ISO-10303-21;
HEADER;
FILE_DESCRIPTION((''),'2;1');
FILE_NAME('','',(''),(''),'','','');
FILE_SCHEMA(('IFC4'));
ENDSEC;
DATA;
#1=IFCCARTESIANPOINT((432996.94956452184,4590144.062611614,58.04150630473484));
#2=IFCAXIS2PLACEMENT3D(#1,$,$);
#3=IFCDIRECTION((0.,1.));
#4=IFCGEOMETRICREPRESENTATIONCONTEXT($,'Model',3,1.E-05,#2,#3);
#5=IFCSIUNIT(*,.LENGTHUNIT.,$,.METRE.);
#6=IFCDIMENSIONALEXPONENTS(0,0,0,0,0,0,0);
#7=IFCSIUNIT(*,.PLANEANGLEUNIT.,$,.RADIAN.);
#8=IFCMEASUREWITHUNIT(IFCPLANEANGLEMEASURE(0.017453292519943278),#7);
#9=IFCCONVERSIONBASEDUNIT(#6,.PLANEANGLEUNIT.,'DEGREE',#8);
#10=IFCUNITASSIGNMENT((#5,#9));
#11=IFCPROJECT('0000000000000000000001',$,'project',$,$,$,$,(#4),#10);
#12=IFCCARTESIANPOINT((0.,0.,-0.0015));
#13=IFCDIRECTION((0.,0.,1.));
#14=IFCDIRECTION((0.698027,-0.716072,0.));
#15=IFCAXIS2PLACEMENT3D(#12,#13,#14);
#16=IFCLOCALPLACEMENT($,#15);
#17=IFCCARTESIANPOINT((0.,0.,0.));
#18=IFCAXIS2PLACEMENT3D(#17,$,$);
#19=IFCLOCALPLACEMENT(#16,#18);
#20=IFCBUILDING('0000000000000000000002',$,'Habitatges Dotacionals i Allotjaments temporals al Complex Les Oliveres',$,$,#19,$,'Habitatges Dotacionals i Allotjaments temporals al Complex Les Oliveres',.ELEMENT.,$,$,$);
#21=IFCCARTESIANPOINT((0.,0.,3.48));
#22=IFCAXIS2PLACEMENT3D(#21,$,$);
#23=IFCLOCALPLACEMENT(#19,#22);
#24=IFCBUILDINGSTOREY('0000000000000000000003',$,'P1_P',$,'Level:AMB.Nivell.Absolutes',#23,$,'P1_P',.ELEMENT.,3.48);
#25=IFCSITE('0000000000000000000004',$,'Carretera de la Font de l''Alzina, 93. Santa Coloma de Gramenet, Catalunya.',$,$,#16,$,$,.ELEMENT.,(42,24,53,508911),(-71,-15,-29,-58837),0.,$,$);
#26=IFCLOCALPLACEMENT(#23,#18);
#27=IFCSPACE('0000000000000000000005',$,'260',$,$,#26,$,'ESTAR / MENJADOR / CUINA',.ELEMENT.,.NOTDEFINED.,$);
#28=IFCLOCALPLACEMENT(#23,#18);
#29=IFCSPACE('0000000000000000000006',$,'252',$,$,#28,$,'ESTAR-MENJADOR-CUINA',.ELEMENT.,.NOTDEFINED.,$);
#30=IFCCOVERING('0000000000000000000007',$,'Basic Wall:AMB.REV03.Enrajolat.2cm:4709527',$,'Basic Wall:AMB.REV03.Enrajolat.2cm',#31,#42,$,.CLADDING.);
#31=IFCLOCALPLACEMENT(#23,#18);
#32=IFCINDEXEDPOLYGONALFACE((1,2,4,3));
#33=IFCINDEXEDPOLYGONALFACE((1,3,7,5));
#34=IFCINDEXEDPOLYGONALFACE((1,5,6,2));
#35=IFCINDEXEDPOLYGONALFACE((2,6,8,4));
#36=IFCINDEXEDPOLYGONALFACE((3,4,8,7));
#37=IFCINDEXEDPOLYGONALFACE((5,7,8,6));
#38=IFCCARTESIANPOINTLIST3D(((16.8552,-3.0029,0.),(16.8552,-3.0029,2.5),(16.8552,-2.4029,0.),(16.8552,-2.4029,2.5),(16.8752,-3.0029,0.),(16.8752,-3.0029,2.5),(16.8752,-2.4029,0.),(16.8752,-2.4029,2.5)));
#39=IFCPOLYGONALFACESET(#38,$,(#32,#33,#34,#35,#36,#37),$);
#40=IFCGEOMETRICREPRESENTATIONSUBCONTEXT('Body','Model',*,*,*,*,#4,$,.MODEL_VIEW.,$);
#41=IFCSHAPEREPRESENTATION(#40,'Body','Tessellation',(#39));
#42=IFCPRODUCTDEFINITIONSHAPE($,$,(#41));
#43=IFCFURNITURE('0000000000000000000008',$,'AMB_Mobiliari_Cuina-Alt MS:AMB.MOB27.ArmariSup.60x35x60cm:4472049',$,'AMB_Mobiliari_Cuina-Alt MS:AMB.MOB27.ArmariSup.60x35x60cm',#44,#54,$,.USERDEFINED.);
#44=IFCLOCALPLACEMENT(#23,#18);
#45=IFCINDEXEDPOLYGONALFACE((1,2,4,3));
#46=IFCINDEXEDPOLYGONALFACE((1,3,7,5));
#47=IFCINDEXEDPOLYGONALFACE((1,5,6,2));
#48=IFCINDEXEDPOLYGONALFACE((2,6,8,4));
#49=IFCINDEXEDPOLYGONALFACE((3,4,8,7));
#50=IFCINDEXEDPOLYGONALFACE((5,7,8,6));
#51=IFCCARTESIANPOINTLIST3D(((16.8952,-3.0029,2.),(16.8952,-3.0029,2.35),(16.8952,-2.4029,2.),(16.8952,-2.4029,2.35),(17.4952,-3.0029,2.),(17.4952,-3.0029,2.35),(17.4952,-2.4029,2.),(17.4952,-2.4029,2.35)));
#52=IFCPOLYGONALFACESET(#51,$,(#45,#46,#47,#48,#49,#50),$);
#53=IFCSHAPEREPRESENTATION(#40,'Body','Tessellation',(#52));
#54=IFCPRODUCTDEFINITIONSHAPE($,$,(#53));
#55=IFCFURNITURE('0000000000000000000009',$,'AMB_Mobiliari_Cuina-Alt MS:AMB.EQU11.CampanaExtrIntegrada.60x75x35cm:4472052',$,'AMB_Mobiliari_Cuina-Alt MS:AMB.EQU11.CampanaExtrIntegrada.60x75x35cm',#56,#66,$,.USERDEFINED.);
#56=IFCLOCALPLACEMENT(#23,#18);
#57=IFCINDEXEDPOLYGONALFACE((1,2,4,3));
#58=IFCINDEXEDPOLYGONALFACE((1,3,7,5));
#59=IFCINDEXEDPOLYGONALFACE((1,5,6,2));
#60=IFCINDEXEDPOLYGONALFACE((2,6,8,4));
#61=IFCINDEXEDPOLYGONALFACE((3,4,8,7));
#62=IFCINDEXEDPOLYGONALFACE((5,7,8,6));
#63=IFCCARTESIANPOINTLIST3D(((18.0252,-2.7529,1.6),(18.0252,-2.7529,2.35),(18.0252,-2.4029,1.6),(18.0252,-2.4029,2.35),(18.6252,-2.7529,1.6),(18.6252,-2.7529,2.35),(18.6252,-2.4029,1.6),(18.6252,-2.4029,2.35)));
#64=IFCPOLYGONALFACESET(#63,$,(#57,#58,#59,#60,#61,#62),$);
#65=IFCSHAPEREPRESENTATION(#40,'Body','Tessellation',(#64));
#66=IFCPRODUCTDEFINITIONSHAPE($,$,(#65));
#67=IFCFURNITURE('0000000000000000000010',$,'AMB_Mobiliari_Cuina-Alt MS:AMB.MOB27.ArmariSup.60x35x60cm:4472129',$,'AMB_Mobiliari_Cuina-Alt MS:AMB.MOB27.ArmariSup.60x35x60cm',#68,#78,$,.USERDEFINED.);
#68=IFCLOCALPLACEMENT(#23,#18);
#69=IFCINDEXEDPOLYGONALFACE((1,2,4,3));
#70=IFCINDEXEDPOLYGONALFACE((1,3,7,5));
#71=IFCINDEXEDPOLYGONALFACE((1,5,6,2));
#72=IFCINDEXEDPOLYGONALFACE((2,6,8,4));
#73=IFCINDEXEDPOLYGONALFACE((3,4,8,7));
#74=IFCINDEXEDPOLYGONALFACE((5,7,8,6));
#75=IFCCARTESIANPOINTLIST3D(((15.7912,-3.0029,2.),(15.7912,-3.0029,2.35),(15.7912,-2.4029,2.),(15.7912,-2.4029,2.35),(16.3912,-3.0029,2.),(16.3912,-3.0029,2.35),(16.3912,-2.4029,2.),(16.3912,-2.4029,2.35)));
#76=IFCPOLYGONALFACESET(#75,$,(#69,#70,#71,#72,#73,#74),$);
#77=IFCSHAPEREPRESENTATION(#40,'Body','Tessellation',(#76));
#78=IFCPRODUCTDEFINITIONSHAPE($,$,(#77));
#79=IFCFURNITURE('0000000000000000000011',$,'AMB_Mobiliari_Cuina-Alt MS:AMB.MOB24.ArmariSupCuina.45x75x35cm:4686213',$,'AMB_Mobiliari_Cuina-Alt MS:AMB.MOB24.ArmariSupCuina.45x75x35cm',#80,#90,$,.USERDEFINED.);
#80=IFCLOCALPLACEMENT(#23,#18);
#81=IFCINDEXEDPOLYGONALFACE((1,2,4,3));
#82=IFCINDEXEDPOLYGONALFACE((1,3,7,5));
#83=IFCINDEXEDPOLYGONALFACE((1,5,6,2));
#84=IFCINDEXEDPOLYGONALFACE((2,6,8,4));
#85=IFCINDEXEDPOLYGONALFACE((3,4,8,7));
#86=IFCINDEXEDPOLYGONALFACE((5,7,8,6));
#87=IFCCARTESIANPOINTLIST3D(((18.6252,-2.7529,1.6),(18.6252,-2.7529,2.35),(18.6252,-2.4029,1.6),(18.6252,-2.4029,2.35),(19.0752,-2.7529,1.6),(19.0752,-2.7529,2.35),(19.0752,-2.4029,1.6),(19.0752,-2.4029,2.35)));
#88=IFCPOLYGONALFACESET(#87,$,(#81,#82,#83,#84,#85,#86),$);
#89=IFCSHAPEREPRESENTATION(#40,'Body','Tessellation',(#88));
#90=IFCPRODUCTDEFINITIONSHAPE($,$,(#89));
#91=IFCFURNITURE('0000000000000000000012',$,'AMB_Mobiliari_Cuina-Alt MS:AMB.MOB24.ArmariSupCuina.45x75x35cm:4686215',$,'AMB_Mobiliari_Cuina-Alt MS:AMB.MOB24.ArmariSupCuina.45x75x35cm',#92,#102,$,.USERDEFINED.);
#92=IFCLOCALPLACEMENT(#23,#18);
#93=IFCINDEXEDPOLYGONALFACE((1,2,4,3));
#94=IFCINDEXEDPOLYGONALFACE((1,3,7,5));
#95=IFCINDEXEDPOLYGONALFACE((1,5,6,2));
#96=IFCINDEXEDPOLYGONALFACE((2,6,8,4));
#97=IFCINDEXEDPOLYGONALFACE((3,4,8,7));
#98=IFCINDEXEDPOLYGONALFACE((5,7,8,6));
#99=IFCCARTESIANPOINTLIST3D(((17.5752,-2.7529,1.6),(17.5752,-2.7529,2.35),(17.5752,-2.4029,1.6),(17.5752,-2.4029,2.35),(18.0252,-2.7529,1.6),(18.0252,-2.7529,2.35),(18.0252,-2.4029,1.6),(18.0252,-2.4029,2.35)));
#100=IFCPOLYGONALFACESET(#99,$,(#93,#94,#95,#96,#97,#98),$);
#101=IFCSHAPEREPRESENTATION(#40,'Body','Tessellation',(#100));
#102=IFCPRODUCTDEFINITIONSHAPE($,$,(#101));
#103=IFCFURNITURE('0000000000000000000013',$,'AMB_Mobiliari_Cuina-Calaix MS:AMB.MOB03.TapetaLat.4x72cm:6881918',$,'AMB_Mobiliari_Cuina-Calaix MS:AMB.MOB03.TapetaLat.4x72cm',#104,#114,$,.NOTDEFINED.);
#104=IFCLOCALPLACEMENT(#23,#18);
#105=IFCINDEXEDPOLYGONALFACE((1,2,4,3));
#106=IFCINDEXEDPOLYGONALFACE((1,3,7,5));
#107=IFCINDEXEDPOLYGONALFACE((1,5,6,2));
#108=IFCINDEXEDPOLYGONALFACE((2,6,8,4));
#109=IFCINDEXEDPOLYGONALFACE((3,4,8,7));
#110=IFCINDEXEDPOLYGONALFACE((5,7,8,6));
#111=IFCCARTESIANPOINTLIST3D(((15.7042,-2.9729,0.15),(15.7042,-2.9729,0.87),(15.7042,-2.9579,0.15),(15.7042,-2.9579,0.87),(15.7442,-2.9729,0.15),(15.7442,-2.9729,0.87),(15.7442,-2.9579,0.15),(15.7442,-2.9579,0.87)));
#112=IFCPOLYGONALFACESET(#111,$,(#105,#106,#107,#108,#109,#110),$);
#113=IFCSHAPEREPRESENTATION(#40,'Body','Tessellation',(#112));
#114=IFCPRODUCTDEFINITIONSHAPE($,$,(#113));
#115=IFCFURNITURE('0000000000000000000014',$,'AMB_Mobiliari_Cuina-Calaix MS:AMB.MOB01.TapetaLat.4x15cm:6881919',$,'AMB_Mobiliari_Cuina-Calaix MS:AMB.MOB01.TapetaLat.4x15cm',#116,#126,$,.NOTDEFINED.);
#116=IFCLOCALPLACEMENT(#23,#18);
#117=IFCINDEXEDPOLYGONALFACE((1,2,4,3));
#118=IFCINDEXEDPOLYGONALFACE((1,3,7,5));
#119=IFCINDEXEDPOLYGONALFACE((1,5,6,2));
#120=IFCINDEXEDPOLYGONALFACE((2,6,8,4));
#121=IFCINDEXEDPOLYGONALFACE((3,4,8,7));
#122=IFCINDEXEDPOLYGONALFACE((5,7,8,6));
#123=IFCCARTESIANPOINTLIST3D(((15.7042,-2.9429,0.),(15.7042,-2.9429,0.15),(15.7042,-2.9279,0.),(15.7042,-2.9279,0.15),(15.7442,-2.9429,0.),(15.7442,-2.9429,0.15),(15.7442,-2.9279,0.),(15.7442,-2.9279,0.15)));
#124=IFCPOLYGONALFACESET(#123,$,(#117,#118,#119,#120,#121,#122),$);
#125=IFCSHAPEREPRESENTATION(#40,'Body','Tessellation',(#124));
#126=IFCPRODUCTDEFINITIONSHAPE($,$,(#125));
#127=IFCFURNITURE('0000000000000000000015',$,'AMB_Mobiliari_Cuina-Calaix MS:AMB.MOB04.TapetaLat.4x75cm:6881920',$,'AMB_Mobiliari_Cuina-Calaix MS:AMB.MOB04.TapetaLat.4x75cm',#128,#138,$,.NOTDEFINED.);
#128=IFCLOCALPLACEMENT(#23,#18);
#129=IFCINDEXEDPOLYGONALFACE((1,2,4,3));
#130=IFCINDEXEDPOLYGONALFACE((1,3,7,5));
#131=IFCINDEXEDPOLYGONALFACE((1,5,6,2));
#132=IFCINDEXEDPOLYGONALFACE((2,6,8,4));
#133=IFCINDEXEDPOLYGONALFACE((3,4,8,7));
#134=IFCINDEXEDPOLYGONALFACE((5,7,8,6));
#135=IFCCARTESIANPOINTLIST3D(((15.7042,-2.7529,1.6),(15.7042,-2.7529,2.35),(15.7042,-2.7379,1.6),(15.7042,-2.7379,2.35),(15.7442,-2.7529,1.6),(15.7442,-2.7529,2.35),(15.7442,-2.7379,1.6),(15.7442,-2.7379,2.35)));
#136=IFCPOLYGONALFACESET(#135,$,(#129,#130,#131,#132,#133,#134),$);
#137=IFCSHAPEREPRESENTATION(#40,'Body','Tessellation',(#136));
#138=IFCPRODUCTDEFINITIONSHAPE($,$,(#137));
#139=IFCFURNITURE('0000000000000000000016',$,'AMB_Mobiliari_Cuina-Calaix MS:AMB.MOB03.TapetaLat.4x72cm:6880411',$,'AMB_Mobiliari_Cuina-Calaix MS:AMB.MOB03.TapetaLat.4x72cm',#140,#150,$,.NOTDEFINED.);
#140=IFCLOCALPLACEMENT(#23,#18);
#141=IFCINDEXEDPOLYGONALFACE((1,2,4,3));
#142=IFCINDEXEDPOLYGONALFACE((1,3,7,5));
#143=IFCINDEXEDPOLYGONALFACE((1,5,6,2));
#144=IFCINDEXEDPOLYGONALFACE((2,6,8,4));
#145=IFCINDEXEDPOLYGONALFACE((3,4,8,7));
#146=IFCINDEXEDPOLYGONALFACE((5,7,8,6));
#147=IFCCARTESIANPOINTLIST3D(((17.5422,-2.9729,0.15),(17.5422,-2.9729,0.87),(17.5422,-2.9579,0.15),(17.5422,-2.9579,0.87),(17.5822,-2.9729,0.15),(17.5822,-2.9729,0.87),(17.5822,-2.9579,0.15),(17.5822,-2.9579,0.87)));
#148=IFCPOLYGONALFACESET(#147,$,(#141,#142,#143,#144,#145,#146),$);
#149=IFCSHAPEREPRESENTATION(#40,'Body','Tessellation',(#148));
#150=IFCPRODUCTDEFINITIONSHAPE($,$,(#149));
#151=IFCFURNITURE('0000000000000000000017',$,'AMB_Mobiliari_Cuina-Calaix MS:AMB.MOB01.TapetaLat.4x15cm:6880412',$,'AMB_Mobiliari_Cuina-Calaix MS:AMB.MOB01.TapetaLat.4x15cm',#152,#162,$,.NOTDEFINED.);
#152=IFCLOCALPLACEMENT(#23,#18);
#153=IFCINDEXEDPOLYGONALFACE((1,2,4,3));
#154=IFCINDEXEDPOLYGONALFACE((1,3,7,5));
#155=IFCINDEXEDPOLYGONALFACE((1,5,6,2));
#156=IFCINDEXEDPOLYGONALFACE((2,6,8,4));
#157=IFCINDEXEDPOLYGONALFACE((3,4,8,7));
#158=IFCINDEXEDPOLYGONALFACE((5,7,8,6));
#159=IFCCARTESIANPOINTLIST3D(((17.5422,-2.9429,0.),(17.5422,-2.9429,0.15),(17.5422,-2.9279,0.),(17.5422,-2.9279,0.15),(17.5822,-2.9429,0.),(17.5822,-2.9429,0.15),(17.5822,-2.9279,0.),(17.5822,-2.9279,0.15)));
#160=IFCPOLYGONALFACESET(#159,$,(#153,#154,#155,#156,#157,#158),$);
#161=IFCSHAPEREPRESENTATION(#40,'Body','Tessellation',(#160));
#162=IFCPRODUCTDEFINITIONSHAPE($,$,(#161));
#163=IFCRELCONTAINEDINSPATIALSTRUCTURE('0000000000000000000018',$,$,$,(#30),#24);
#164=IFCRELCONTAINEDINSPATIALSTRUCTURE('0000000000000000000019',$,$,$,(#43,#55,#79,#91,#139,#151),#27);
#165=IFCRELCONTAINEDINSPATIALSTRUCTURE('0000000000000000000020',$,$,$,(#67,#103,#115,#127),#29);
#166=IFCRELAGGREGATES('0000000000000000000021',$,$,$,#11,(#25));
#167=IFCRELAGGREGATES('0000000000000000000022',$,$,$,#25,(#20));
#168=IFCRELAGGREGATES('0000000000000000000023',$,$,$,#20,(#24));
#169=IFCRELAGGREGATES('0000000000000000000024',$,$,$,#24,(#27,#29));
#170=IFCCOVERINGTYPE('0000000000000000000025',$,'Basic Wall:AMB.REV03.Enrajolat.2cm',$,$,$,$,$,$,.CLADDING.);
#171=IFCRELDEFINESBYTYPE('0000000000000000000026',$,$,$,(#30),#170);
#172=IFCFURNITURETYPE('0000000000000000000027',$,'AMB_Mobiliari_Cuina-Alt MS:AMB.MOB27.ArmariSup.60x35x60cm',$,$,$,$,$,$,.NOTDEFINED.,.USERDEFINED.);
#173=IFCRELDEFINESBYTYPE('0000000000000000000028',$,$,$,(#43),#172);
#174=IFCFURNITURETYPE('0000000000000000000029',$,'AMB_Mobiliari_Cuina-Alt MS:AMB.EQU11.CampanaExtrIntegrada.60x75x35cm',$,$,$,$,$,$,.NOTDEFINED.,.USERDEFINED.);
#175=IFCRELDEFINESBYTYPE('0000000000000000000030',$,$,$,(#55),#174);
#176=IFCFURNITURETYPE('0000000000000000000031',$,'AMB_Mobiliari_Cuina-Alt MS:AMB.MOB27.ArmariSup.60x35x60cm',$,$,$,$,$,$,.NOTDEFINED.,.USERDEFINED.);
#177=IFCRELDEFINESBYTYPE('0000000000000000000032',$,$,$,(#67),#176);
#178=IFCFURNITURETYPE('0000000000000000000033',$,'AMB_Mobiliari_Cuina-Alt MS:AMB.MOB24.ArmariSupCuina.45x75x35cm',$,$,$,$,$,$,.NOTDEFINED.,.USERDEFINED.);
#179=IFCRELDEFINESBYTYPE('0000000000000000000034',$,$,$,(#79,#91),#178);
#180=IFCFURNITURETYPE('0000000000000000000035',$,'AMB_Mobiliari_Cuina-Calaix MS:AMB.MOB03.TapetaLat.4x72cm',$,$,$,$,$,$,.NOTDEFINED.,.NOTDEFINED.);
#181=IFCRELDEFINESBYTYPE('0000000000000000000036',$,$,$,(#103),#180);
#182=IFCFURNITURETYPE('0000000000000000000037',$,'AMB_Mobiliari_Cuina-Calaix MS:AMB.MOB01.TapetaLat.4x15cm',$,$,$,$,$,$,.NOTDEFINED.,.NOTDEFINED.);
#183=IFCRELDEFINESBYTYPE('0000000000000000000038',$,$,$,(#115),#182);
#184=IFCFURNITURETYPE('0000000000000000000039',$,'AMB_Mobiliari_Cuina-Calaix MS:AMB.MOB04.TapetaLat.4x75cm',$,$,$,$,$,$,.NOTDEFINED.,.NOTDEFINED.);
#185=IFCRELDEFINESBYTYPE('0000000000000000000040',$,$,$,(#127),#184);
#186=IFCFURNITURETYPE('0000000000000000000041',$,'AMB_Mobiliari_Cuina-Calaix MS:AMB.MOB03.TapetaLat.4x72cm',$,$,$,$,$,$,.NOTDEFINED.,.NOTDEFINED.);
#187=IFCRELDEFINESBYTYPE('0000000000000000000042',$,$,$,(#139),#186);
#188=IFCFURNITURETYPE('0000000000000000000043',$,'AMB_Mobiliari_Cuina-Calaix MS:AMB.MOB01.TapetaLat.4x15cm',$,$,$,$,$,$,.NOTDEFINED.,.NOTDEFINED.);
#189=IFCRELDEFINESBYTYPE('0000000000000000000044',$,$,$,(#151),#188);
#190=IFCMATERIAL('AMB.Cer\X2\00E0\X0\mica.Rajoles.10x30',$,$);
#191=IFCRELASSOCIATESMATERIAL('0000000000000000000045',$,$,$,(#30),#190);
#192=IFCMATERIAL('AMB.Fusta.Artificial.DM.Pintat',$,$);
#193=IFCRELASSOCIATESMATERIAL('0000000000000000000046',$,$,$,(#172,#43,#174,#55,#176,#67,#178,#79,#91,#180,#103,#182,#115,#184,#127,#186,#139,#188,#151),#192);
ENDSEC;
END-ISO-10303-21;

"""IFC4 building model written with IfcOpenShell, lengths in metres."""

from ifc_helpers import new_model, entity, si_unit, converted_unit, direction, frame, origin, place, context, subcontext, project, spatial, indexed_curve, outline, extrude, source, transform, mapped, material, type_object, type_shapes, element, save


model = new_model("IFC4")

# Units and contexts
model_context = context("Model", 3, precision=1e-05, world=frame((432996.94956452184, 4590144.062611614, 58.04150630473484)), true_north=direction((0.0, 1.0)))
body_context = subcontext(model_context, "Body", "Model", "MODEL_VIEW")
ifc_project = project(units=[si_unit("LENGTHUNIT", "METRE"), converted_unit("PLANEANGLEUNIT", "DEGREE", entity("IfcPlaneAngleMeasure", 0.017453292519943278), si_unit("PLANEANGLEUNIT", "RADIAN"), dimensions=[0, 0, 0, 0, 0, 0, 0])], contexts=[model_context])

# Site, building, storey
site_placement = place(None, frame((0.0, 0.0, -0.0015), z_axis=(0.0, 0.0, 1.0), x_axis=(0.698027, -0.716072, 0.0)))
site = spatial("IfcSite", under=ifc_project, at=site_placement, Name="Carretera de la Font de l'Alzina, 93. Santa Coloma de Gramenet, Catalunya.", CompositionType="ELEMENT", RefLatitude=(42, 24, 53, 508911), RefLongitude=(-71, -15, -29, -58837), RefElevation=0.0)
building_placement = place(site_placement, origin())
building = spatial("IfcBuilding", under=site, at=building_placement, Name="Habitatges Dotacionals i Allotjaments temporals al Complex Les Oliveres", LongName="Habitatges Dotacionals i Allotjaments temporals al Complex Les Oliveres", CompositionType="ELEMENT")
storey_placement = place(building_placement, frame((0.0, 0.0, 3.48)))
storey = spatial("IfcBuildingStorey", under=building, at=storey_placement, Name="P1_P", ObjectType="Level:AMB.Nivell.Absolutes", LongName="P1_P", CompositionType="ELEMENT", Elevation=3.48)

# Shared definitions
ifc_material_1 = material(Name="AMB.Fusta.Artificial.DM.Pintat")

# Covering
ifc_material_2 = material(Name="AMB.Ceràmica.Rajoles.10x30")
covering_type = type_object("IfcCoveringType", Name="Basic Wall:AMB.REV03.Enrajolat.2cm", PredefinedType="CLADDING")
covering_1_placement = place(storey_placement, frame((16.8652, -3.0029, 0.0), z_axis=(0.0, 0.0, 1.0), x_axis=(0.0, 1.0, 0.0)))
element("IfcCovering", 1, at=covering_1_placement, inside=storey, type_object=covering_type, material=ifc_material_2, Name="Basic Wall:AMB.REV03.Enrajolat.2cm:4709527", ObjectType="Basic Wall:AMB.REV03.Enrajolat.2cm", PredefinedType="CLADDING", context=body_context, shape_type="SweptSolid", body=[
    extrude(outline(indexed_curve([(0.6, 0.01), (0.0, 0.01), (0.0, -0.01), (0.6, -0.01), (0.6, 0.01)], self_intersect=False)), origin(), (0.0, 0.0, 1.0), 2.5),
])

# Shared definitions
space_1_placement = place(storey_placement, origin())
space_1 = spatial("IfcSpace", under=storey, at=space_1_placement, Name="260", LongName="ESTAR / MENJADOR / CUINA", CompositionType="ELEMENT", PredefinedType="NOTDEFINED")

# Furniture
furniture_type_1 = type_object("IfcFurnitureType", Name="AMB_Mobiliari_Cuina-Alt MS:AMB.MOB27.ArmariSup.60x35x60cm", AssemblyPlace="NOTDEFINED", PredefinedType="USERDEFINED", material=ifc_material_1)
shared_shape_1 = source(origin(), body_context, "Body", "SweptSolid", [
    extrude(outline(indexed_curve([(-0.3, -0.3), (0.3, -0.3), (0.3, 0.3), (-0.3, 0.3), (-0.3, -0.3)], self_intersect=False)), frame((-0.5175, 0.3, 0.0), z_axis=(0.0, 0.0, 1.0), x_axis=(0.0, 1.0, 0.0)), (0.0, 0.0, 1.0), 0.35),
])
type_shapes(furniture_type_1, [shared_shape_1])
furniture_1_placement = place(space_1_placement, frame((16.6777, -2.4029, 2.0), z_axis=(0.0, 0.0, 1.0), x_axis=(-1.0, 0.0, 0.0)))
element("IfcFurniture", 2, at=furniture_1_placement, inside=space_1, type_object=furniture_type_1, material=ifc_material_1, Name="AMB_Mobiliari_Cuina-Alt MS:AMB.MOB27.ArmariSup.60x35x60cm:4472049", ObjectType="AMB_Mobiliari_Cuina-Alt MS:AMB.MOB27.ArmariSup.60x35x60cm", PredefinedType="USERDEFINED", context=body_context, shape_type="MappedRepresentation", body=[
    mapped(shared_shape_1, transform((0.0, 0.0, 0.0), scale=1.0)),
])
furniture_type_2 = type_object("IfcFurnitureType", Name="AMB_Mobiliari_Cuina-Alt MS:AMB.EQU11.CampanaExtrIntegrada.60x75x35cm", AssemblyPlace="NOTDEFINED", PredefinedType="USERDEFINED", material=ifc_material_1)
shared_shape_2 = source(origin(), body_context, "Body", "SweptSolid", [
    extrude(outline(indexed_curve([(-0.175, -0.3), (0.175, -0.3), (0.175, 0.3), (-0.175, 0.3), (-0.175, -0.3)], self_intersect=False)), frame((-0.5175, 0.175, 0.0), z_axis=(0.0, 0.0, 1.0), x_axis=(0.0, 1.0, 0.0)), (0.0, 0.0, 1.0), 0.75),
])
type_shapes(furniture_type_2, [shared_shape_2])
furniture_2_placement = place(space_1_placement, frame((17.8077, -2.4029, 1.6), z_axis=(0.0, 0.0, 1.0), x_axis=(-1.0, 0.0, 0.0)))
element("IfcFurniture", 3, at=furniture_2_placement, inside=space_1, type_object=furniture_type_2, material=ifc_material_1, Name="AMB_Mobiliari_Cuina-Alt MS:AMB.EQU11.CampanaExtrIntegrada.60x75x35cm:4472052", ObjectType="AMB_Mobiliari_Cuina-Alt MS:AMB.EQU11.CampanaExtrIntegrada.60x75x35cm", PredefinedType="USERDEFINED", context=body_context, shape_type="MappedRepresentation", body=[
    mapped(shared_shape_2, transform((0.0, 0.0, 0.0), scale=1.0)),
])

# Shared definitions
space_2_placement = place(storey_placement, origin())
space_2 = spatial("IfcSpace", under=storey, at=space_2_placement, Name="252", LongName="ESTAR-MENJADOR-CUINA", CompositionType="ELEMENT", PredefinedType="NOTDEFINED")

# Furniture
furniture_type_3 = type_object("IfcFurnitureType", Name="AMB_Mobiliari_Cuina-Alt MS:AMB.MOB27.ArmariSup.60x35x60cm", AssemblyPlace="NOTDEFINED", PredefinedType="USERDEFINED", material=ifc_material_1)
shared_shape_3 = source(origin(), body_context, "Body", "SweptSolid", [
    extrude(outline(indexed_curve([(-0.3, -0.3), (0.3, -0.3), (0.3, 0.3), (-0.3, 0.3), (-0.3, -0.3)], self_intersect=False)), frame((-0.5175, -0.3, 0.0), z_axis=(0.0, 0.0, 1.0), x_axis=(-1.0, 0.0, 0.0)), (0.0, 0.0, 1.0), 0.35),
])
type_shapes(furniture_type_3, [shared_shape_3])
furniture_3_placement = place(space_2_placement, frame((16.6087, -2.4029, 2.0)))
element("IfcFurniture", 4, at=furniture_3_placement, inside=space_2, type_object=furniture_type_3, material=ifc_material_1, Name="AMB_Mobiliari_Cuina-Alt MS:AMB.MOB27.ArmariSup.60x35x60cm:4472129", ObjectType="AMB_Mobiliari_Cuina-Alt MS:AMB.MOB27.ArmariSup.60x35x60cm", PredefinedType="USERDEFINED", context=body_context, shape_type="MappedRepresentation", body=[
    mapped(shared_shape_3, transform((0.0, 0.0, 0.0), scale=1.0)),
])
furniture_type_4 = type_object("IfcFurnitureType", Name="AMB_Mobiliari_Cuina-Alt MS:AMB.MOB24.ArmariSupCuina.45x75x35cm", AssemblyPlace="NOTDEFINED", PredefinedType="USERDEFINED", material=ifc_material_1)
shared_shape_4 = source(origin(), body_context, "Body", "SweptSolid", [
    extrude(outline(indexed_curve([(-0.175, -0.225), (0.175, -0.225), (0.175, 0.225), (-0.175, 0.225), (-0.175, -0.225)], self_intersect=False)), frame((-0.5925, 0.175, 0.0), z_axis=(0.0, 0.0, 1.0), x_axis=(0.0, 1.0, 0.0)), (0.0, 0.0, 1.0), 0.75),
])
type_shapes(furniture_type_4, [shared_shape_4])
for number, where, z_axis, x_axis, name in (
    (5, (18.2577, -2.4029, 1.6), (0.0, 0.0, 1.0), (-1.0, 0.0, 0.0), "AMB_Mobiliari_Cuina-Alt MS:AMB.MOB24.ArmariSupCuina.45x75x35cm:4686213"),
    (6, (17.2077, -2.4029, 1.6), (0.0, 0.0, 1.0), (-1.0, 0.0, 0.0), "AMB_Mobiliari_Cuina-Alt MS:AMB.MOB24.ArmariSupCuina.45x75x35cm:4686215"),
):
    element("IfcFurniture", number, at=place(space_1_placement, frame(where, z_axis=z_axis, x_axis=x_axis)), inside=space_1, type_object=furniture_type_4, material=ifc_material_1, Name=name, ObjectType="AMB_Mobiliari_Cuina-Alt MS:AMB.MOB24.ArmariSupCuina.45x75x35cm", PredefinedType="USERDEFINED", context=body_context, shape_type="MappedRepresentation", body=[
        mapped(shared_shape_4, transform((0.0, 0.0, 0.0), scale=1.0)),
    ])
furniture_type_5 = type_object("IfcFurnitureType", Name="AMB_Mobiliari_Cuina-Calaix MS:AMB.MOB03.TapetaLat.4x72cm", AssemblyPlace="NOTDEFINED", PredefinedType="NOTDEFINED", material=ifc_material_1)
shared_shape_5 = source(origin(), body_context, "Body", "SweptSolid", [
    extrude(outline(indexed_curve([(-0.02, -0.0075), (0.02, -0.0075), (0.02, 0.0075), (-0.02, 0.0075), (-0.02, -0.0075)], self_intersect=False)), frame((-0.8045, -0.0075, 0.0), z_axis=(0.0, 0.0, 1.0), x_axis=(-1.0, 0.0, 0.0)), (0.0, 0.0, 1.0), 0.72),
])
type_shapes(furniture_type_5, [shared_shape_5])
furniture_4_placement = place(space_2_placement, frame((16.5287, -2.9579, 0.15)))
element("IfcFurniture", 7, at=furniture_4_placement, inside=space_2, type_object=furniture_type_5, material=ifc_material_1, Name="AMB_Mobiliari_Cuina-Calaix MS:AMB.MOB03.TapetaLat.4x72cm:6881918", ObjectType="AMB_Mobiliari_Cuina-Calaix MS:AMB.MOB03.TapetaLat.4x72cm", PredefinedType="NOTDEFINED", context=body_context, shape_type="MappedRepresentation", body=[
    mapped(shared_shape_5, transform((0.0, 0.0, 0.0), scale=1.0)),
])
furniture_type_6 = type_object("IfcFurnitureType", Name="AMB_Mobiliari_Cuina-Calaix MS:AMB.MOB01.TapetaLat.4x15cm", AssemblyPlace="NOTDEFINED", PredefinedType="NOTDEFINED", material=ifc_material_1)
shared_shape_6 = source(origin(), body_context, "Body", "SweptSolid", [
    extrude(outline(indexed_curve([(-0.02, -0.0075), (0.02, -0.0075), (0.02, 0.0075), (-0.02, 0.0075), (-0.02, -0.0075)], self_intersect=False)), frame((-0.8045, -0.0075, 0.0), z_axis=(0.0, 0.0, 1.0), x_axis=(-1.0, 0.0, 0.0)), (0.0, 0.0, 1.0), 0.15),
])
type_shapes(furniture_type_6, [shared_shape_6])
furniture_5_placement = place(space_2_placement, frame((16.5287, -2.9279, 0.0)))
element("IfcFurniture", 8, at=furniture_5_placement, inside=space_2, type_object=furniture_type_6, material=ifc_material_1, Name="AMB_Mobiliari_Cuina-Calaix MS:AMB.MOB01.TapetaLat.4x15cm:6881919", ObjectType="AMB_Mobiliari_Cuina-Calaix MS:AMB.MOB01.TapetaLat.4x15cm", PredefinedType="NOTDEFINED", context=body_context, shape_type="MappedRepresentation", body=[
    mapped(shared_shape_6, transform((0.0, 0.0, 0.0), scale=1.0)),
])
furniture_type_7 = type_object("IfcFurnitureType", Name="AMB_Mobiliari_Cuina-Calaix MS:AMB.MOB04.TapetaLat.4x75cm", AssemblyPlace="NOTDEFINED", PredefinedType="NOTDEFINED", material=ifc_material_1)
shared_shape_7 = source(origin(), body_context, "Body", "SweptSolid", [
    extrude(outline(indexed_curve([(-0.02, -0.0075), (0.02, -0.0075), (0.02, 0.0075), (-0.02, 0.0075), (-0.02, -0.0075)], self_intersect=False)), frame((-0.8045, -0.0075, 0.0), z_axis=(0.0, 0.0, 1.0), x_axis=(-1.0, 0.0, 0.0)), (0.0, 0.0, 1.0), 0.75),
])
type_shapes(furniture_type_7, [shared_shape_7])
furniture_6_placement = place(space_2_placement, frame((16.5287, -2.7379, 1.6)))
element("IfcFurniture", 9, at=furniture_6_placement, inside=space_2, type_object=furniture_type_7, material=ifc_material_1, Name="AMB_Mobiliari_Cuina-Calaix MS:AMB.MOB04.TapetaLat.4x75cm:6881920", ObjectType="AMB_Mobiliari_Cuina-Calaix MS:AMB.MOB04.TapetaLat.4x75cm", PredefinedType="NOTDEFINED", context=body_context, shape_type="MappedRepresentation", body=[
    mapped(shared_shape_7, transform((0.0, 0.0, 0.0), scale=1.0)),
])
furniture_type_8 = type_object("IfcFurnitureType", Name="AMB_Mobiliari_Cuina-Calaix MS:AMB.MOB03.TapetaLat.4x72cm", AssemblyPlace="NOTDEFINED", PredefinedType="NOTDEFINED", material=ifc_material_1)
shared_shape_8 = source(origin(), body_context, "Body", "SweptSolid", [
    extrude(outline(indexed_curve([(-0.0075, -0.02), (0.0075, -0.02), (0.0075, 0.02), (-0.0075, 0.02), (-0.0075, -0.02)], self_intersect=False)), frame((-0.8045, 0.0075, 0.0), z_axis=(0.0, 0.0, 1.0), x_axis=(0.0, 1.0, 0.0)), (0.0, 0.0, 1.0), 0.72),
])
type_shapes(furniture_type_8, [shared_shape_8])
furniture_7_placement = place(space_1_placement, frame((16.7577, -2.9579, 0.15), z_axis=(0.0, 0.0, 1.0), x_axis=(-1.0, 0.0, 0.0)))
element("IfcFurniture", 10, at=furniture_7_placement, inside=space_1, type_object=furniture_type_8, material=ifc_material_1, Name="AMB_Mobiliari_Cuina-Calaix MS:AMB.MOB03.TapetaLat.4x72cm:6880411", ObjectType="AMB_Mobiliari_Cuina-Calaix MS:AMB.MOB03.TapetaLat.4x72cm", PredefinedType="NOTDEFINED", context=body_context, shape_type="MappedRepresentation", body=[
    mapped(shared_shape_8, transform((0.0, 0.0, 0.0), scale=1.0)),
])
furniture_type_9 = type_object("IfcFurnitureType", Name="AMB_Mobiliari_Cuina-Calaix MS:AMB.MOB01.TapetaLat.4x15cm", AssemblyPlace="NOTDEFINED", PredefinedType="NOTDEFINED", material=ifc_material_1)
shared_shape_9 = source(origin(), body_context, "Body", "SweptSolid", [
    extrude(outline(indexed_curve([(-0.0075, -0.02), (0.0075, -0.02), (0.0075, 0.02), (-0.0075, 0.02), (-0.0075, -0.02)], self_intersect=False)), frame((-0.8045, 0.0075, 0.0), z_axis=(0.0, 0.0, 1.0), x_axis=(0.0, 1.0, 0.0)), (0.0, 0.0, 1.0), 0.15),
])
type_shapes(furniture_type_9, [shared_shape_9])
furniture_8_placement = place(space_1_placement, frame((16.7577, -2.9279, 0.0), z_axis=(0.0, 0.0, 1.0), x_axis=(-1.0, 0.0, 0.0)))
element("IfcFurniture", 11, at=furniture_8_placement, inside=space_1, type_object=furniture_type_9, material=ifc_material_1, Name="AMB_Mobiliari_Cuina-Calaix MS:AMB.MOB01.TapetaLat.4x15cm:6880412", ObjectType="AMB_Mobiliari_Cuina-Calaix MS:AMB.MOB01.TapetaLat.4x15cm", PredefinedType="NOTDEFINED", context=body_context, shape_type="MappedRepresentation", body=[
    mapped(shared_shape_9, transform((0.0, 0.0, 0.0), scale=1.0)),
])

save(model, "model.ifc")
